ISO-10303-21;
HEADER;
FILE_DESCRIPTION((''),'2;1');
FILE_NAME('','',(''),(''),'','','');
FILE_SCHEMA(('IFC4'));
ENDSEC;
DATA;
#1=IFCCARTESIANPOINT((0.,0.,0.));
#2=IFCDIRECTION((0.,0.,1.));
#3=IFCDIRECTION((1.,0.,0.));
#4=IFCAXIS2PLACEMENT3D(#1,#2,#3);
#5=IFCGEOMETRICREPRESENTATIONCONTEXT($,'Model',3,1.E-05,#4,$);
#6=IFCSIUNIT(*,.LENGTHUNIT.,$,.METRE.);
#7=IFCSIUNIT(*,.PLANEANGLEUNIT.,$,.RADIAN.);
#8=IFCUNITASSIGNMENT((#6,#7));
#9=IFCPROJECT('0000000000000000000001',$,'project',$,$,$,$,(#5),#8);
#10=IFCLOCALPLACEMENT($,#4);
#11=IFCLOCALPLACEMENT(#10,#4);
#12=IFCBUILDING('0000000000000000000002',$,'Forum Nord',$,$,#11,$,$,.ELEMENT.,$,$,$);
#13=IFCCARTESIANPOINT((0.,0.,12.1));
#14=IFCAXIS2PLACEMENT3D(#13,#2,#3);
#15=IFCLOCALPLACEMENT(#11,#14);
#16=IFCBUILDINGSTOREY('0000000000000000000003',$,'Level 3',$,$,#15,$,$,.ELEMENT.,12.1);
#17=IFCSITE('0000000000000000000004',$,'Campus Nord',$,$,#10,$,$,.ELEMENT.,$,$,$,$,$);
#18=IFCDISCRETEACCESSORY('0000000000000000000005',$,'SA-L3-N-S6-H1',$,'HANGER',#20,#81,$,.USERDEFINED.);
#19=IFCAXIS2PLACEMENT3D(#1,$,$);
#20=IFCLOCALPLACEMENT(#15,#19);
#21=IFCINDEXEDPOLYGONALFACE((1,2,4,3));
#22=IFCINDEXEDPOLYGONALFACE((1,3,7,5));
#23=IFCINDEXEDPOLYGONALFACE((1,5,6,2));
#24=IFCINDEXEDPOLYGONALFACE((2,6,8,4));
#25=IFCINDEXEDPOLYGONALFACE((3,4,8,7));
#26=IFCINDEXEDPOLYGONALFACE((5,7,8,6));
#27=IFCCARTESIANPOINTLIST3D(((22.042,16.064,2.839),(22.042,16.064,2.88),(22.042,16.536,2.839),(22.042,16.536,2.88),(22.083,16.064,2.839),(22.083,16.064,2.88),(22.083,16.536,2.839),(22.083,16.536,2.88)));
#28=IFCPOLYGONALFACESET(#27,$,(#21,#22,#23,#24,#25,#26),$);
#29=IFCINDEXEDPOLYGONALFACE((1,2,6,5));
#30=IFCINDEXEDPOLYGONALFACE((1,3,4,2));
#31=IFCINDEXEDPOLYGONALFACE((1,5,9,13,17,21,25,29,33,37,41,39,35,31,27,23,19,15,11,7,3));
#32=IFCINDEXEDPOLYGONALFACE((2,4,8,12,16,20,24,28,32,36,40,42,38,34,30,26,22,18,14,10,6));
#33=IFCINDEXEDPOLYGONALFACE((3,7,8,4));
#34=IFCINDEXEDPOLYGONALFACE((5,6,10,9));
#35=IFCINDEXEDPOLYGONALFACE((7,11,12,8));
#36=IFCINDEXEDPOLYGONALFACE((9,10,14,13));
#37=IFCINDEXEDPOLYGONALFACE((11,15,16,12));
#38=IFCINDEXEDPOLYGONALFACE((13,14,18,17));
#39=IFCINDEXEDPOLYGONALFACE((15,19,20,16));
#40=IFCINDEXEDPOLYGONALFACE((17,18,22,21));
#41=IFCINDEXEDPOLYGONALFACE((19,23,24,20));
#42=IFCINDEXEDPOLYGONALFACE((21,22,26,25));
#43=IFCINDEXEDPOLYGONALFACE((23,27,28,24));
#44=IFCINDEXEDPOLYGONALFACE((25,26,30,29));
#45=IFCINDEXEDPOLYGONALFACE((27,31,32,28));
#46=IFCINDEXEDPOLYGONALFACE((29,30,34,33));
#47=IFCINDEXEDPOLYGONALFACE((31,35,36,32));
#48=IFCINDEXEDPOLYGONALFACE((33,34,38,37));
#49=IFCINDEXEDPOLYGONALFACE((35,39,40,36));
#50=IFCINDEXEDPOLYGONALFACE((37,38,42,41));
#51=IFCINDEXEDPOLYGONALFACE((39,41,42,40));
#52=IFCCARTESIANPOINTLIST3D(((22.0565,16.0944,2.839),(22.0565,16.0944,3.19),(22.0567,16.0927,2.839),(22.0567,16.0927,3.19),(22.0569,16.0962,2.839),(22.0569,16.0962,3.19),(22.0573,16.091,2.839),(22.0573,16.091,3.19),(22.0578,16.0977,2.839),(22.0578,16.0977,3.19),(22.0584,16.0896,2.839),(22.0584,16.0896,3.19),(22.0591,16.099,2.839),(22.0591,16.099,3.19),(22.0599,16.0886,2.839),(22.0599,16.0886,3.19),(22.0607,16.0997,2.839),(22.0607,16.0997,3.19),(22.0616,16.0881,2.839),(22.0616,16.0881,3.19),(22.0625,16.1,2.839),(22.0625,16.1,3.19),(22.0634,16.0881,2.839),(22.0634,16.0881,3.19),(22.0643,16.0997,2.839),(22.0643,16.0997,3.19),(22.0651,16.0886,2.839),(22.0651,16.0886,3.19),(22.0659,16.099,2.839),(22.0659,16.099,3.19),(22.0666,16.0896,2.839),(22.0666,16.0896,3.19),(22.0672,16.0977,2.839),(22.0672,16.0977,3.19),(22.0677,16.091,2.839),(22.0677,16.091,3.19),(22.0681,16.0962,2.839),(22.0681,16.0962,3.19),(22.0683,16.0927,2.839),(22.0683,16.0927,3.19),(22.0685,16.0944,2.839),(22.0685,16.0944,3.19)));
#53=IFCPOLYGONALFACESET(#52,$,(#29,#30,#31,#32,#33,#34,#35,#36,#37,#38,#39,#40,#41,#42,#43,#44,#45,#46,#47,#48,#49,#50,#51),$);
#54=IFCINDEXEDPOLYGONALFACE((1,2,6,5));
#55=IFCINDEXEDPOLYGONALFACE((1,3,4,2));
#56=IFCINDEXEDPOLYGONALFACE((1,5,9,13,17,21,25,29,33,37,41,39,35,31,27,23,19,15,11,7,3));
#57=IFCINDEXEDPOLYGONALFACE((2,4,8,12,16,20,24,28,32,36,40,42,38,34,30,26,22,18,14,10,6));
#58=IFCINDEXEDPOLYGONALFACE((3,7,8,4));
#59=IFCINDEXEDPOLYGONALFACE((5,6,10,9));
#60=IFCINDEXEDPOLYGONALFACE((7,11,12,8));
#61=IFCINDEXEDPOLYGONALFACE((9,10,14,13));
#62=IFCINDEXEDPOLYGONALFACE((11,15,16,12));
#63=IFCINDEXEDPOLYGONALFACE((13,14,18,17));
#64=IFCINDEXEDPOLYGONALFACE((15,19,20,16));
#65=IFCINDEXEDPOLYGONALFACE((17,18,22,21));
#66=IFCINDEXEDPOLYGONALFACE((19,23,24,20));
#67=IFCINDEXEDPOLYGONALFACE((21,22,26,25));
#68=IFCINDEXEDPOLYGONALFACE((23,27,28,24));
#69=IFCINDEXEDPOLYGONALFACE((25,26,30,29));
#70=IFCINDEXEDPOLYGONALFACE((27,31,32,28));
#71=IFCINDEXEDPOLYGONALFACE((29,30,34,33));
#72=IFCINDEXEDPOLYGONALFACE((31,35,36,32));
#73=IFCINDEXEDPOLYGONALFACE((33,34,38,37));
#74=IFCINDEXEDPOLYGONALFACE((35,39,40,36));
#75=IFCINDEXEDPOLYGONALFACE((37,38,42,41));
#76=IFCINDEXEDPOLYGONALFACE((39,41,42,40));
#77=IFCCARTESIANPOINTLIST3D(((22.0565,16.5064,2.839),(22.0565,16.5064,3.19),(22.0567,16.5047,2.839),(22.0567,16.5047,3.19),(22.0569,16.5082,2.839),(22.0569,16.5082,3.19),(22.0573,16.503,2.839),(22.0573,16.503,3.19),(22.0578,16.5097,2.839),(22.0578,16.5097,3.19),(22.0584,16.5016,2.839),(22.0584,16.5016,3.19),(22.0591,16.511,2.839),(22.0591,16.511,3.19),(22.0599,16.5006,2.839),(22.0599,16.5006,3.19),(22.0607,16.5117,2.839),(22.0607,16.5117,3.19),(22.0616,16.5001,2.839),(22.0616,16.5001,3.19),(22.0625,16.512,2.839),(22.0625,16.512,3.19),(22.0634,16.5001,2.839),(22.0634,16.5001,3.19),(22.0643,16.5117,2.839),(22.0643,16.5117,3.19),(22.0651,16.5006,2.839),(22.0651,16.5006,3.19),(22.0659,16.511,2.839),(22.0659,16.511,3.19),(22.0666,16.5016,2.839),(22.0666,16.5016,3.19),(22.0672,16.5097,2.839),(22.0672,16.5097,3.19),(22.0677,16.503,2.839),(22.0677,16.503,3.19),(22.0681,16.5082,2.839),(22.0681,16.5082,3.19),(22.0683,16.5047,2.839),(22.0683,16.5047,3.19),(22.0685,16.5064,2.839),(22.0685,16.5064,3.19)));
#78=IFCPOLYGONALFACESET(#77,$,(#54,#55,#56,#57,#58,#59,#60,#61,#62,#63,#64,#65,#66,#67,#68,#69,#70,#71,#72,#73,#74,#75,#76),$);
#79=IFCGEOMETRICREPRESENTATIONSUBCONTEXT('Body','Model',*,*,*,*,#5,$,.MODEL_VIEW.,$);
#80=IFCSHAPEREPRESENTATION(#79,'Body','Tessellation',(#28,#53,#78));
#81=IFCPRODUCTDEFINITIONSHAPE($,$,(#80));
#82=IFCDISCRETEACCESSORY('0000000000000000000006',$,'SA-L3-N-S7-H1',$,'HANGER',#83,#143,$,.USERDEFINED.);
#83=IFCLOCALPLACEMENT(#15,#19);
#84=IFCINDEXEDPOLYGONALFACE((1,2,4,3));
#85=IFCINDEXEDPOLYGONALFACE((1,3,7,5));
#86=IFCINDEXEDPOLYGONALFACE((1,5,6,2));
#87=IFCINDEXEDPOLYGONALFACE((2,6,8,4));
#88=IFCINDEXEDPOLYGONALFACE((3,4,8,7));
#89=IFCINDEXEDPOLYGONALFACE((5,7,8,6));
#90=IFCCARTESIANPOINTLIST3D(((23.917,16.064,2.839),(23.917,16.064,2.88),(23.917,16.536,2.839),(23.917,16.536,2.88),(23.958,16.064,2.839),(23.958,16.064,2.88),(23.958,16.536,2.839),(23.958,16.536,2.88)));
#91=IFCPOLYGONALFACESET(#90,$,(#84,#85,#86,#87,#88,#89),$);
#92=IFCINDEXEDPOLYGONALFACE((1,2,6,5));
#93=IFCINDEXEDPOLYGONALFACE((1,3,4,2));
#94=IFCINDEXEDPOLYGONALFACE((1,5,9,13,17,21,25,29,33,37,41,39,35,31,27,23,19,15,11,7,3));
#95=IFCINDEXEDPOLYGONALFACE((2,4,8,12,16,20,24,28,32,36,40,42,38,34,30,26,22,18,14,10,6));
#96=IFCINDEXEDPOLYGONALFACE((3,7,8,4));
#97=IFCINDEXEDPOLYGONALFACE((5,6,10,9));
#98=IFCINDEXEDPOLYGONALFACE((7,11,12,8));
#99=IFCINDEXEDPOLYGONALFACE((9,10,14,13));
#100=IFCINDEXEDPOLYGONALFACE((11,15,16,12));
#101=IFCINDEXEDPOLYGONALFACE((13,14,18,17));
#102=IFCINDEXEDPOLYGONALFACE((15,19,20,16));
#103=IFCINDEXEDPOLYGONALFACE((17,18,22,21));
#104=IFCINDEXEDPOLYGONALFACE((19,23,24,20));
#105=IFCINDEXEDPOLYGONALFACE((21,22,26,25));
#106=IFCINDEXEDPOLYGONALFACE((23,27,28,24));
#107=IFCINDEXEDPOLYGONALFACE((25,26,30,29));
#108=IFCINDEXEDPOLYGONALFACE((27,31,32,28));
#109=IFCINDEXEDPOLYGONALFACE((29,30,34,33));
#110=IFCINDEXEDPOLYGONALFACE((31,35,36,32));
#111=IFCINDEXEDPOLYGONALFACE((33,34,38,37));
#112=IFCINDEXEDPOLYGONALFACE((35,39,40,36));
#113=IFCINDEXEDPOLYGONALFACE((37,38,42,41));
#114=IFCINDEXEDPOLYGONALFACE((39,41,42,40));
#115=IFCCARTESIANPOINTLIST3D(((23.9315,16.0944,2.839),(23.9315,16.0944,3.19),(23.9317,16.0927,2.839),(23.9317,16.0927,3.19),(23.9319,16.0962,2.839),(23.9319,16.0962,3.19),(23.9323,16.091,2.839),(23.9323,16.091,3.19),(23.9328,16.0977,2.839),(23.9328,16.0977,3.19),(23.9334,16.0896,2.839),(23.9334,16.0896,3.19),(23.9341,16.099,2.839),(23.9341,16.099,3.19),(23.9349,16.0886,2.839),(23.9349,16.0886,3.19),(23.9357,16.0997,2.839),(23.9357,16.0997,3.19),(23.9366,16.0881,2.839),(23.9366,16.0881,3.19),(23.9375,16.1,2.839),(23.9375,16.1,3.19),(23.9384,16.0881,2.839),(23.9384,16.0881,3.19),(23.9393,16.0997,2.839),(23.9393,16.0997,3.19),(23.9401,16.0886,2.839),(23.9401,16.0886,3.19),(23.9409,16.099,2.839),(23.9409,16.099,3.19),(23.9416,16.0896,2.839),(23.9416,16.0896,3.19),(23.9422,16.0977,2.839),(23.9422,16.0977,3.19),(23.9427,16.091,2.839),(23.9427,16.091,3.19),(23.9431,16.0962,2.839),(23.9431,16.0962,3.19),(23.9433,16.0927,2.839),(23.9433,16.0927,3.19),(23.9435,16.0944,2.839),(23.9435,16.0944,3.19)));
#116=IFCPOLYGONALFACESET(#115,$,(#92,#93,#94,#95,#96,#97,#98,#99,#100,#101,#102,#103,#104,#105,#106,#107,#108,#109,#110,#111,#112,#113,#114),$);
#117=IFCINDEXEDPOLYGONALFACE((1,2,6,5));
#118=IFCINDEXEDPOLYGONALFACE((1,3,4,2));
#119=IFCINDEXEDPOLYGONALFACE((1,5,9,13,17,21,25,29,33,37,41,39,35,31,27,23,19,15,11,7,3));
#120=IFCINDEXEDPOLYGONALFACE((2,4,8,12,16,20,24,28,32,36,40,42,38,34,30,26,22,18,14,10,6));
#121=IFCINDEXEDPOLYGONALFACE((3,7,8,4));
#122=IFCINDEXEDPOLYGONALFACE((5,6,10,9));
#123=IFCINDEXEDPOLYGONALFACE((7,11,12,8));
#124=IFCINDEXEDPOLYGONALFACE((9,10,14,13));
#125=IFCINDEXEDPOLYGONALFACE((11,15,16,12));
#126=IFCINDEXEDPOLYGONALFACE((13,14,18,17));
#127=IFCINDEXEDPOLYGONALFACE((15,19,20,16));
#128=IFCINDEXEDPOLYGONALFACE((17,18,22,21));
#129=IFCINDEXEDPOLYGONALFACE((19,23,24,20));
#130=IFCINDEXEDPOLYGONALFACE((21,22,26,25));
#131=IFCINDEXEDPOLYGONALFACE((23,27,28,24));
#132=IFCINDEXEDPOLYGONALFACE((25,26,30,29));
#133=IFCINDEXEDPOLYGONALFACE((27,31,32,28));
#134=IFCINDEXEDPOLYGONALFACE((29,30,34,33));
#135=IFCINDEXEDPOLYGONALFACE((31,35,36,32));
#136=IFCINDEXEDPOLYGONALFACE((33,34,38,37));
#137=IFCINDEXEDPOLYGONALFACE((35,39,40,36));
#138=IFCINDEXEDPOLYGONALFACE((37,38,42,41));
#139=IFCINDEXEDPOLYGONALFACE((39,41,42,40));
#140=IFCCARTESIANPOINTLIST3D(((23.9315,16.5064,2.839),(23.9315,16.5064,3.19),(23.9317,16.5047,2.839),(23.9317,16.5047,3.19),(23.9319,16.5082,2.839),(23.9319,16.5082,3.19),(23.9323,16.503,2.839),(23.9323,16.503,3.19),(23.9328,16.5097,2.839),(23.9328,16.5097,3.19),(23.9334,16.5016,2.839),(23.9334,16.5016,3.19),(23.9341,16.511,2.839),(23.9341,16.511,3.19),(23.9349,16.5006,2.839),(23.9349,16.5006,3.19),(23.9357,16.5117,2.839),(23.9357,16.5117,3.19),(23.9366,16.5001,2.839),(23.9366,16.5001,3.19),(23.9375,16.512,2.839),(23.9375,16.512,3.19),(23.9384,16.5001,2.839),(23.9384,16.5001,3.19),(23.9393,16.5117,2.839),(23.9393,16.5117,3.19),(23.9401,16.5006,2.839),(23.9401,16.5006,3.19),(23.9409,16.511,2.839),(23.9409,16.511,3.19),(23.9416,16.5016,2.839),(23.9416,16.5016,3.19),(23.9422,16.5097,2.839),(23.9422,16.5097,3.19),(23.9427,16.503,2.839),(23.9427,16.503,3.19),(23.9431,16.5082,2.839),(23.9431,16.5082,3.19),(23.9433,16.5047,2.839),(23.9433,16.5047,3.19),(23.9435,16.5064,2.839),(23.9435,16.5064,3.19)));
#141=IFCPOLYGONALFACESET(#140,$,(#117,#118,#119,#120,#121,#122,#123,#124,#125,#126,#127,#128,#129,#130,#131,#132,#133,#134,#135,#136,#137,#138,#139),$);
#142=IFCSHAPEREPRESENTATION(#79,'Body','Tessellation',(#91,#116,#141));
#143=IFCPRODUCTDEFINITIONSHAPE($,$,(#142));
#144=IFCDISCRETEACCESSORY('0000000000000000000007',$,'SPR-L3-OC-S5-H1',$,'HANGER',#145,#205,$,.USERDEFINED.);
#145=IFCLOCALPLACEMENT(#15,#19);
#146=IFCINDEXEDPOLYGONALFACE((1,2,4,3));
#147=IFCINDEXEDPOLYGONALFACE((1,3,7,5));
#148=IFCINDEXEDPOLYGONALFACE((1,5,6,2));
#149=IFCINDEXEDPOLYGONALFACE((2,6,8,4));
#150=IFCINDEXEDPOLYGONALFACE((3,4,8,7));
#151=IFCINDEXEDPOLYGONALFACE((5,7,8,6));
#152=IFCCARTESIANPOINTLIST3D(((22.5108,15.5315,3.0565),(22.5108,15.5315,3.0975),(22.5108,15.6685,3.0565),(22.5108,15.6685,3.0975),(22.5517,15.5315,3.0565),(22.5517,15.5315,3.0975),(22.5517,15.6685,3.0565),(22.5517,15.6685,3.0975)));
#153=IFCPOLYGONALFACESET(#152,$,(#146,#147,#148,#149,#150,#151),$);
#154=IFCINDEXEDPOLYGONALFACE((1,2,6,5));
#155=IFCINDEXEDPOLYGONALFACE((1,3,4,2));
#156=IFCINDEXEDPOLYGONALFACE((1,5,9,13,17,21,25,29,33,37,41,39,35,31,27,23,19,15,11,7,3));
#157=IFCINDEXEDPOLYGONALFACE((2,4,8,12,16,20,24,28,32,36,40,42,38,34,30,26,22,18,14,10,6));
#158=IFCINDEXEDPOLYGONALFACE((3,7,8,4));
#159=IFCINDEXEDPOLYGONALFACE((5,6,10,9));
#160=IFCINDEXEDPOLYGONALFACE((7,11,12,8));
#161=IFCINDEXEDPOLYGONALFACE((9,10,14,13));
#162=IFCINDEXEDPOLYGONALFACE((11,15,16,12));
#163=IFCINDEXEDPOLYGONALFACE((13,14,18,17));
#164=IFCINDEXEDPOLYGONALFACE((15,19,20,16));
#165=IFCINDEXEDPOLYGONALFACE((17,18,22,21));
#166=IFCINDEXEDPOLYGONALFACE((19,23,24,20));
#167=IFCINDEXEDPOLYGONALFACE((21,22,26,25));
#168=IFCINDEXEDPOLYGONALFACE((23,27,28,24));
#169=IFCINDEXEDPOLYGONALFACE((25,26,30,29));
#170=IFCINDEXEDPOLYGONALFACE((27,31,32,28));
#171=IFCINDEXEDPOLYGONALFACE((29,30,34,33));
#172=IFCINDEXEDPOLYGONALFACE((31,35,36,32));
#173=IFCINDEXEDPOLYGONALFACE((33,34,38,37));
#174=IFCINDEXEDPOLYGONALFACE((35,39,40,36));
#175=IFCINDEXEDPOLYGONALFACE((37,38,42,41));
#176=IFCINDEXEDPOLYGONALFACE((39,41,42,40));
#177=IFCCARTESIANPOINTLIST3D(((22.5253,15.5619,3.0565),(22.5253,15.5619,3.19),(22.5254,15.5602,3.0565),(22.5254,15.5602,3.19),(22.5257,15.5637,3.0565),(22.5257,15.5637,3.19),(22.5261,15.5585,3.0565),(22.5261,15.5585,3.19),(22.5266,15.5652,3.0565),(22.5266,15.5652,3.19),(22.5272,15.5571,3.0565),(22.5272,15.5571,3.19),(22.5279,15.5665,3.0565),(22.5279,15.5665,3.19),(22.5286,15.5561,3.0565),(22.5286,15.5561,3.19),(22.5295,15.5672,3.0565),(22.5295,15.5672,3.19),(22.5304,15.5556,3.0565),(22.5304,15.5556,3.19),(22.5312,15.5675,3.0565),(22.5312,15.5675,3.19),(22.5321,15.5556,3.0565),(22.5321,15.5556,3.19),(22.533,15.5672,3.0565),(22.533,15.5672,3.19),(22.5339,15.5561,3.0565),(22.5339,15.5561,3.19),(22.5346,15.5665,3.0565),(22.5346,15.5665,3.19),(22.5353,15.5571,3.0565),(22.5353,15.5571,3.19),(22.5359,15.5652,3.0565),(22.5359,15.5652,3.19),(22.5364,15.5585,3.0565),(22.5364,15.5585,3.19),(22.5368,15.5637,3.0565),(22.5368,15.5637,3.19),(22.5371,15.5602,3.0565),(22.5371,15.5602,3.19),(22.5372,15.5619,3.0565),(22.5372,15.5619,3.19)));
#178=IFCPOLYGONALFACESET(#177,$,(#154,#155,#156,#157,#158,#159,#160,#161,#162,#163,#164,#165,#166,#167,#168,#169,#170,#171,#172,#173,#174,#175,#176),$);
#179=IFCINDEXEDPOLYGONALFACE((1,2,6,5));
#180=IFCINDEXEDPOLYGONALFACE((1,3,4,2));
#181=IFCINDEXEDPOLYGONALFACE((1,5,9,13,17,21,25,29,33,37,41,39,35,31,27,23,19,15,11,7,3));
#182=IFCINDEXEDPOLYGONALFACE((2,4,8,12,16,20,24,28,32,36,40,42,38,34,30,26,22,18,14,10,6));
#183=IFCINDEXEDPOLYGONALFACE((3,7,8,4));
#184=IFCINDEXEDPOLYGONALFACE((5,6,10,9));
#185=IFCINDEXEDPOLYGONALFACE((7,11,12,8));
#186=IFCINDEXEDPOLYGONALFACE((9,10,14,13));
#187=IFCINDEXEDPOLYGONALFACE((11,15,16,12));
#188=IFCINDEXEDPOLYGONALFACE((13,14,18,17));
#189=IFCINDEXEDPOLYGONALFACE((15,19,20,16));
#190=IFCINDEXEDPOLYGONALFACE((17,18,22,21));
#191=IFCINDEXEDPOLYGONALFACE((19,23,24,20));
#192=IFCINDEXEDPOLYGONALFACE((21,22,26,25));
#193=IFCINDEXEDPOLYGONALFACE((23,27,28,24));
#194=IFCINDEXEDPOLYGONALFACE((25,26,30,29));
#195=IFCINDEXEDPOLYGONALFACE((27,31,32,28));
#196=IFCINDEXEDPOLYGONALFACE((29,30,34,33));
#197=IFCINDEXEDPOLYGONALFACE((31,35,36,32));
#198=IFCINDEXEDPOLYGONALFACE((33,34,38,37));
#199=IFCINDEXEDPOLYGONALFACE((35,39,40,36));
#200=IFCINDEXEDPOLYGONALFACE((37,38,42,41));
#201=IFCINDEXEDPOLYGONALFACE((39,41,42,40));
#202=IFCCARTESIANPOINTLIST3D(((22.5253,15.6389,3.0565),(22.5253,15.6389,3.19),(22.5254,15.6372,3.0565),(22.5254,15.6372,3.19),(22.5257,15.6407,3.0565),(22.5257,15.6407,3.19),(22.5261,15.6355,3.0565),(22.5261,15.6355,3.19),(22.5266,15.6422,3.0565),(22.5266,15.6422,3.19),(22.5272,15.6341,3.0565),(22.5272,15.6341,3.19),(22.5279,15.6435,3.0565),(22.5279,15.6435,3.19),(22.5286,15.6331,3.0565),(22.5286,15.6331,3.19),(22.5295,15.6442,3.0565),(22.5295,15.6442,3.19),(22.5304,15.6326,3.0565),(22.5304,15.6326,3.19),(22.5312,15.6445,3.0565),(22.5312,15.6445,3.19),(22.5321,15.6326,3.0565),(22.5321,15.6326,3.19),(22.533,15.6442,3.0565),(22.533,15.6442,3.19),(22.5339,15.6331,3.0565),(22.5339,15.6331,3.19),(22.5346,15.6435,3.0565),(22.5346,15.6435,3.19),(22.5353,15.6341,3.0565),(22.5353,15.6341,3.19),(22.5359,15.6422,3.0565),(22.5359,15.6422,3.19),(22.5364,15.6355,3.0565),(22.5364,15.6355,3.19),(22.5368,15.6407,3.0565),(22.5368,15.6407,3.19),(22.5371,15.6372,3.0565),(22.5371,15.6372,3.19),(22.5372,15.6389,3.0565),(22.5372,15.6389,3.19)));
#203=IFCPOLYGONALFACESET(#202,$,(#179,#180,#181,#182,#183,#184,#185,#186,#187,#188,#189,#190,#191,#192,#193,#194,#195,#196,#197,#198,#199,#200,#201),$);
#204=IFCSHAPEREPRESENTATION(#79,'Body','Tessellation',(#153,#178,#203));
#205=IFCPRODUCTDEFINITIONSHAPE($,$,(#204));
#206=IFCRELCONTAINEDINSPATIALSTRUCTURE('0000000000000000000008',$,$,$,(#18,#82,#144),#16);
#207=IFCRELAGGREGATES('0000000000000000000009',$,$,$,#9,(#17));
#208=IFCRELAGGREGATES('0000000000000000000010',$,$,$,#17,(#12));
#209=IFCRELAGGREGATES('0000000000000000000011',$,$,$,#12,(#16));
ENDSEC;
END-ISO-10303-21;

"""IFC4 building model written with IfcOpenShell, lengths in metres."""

from ifc_helpers import new_model, si_unit, frame, frame_2d, origin_with_axes, origin_2d_with_axis, place, context, subcontext, project, spatial, rectangle, circle, extrude, element, save


model = new_model("IFC4")

# Units and contexts
model_context = context("Model", 3, precision=1e-05, world=origin_with_axes())
body_context = subcontext(model_context, "Body", "Model", "MODEL_VIEW")
ifc_project = project(units=[si_unit("LENGTHUNIT", "METRE"), si_unit("PLANEANGLEUNIT", "RADIAN")], contexts=[model_context])

# Site, building, storey
site_placement = place(None, origin_with_axes())
site = spatial("IfcSite", under=ifc_project, at=site_placement, Name="Campus Nord", CompositionType="ELEMENT")
building_placement = place(site_placement, origin_with_axes())
building = spatial("IfcBuilding", under=site, at=building_placement, Name="Forum Nord", CompositionType="ELEMENT")
storey_placement = place(building_placement, frame((0.0, 0.0, 12.1), z_axis=(0.0, 0.0, 1.0), x_axis=(1.0, 0.0, 0.0)))
storey = spatial("IfcBuildingStorey", under=building, at=storey_placement, Name="Level 3", CompositionType="ELEMENT", Elevation=12.1)

# Discrete accessories
for number, where, z_axis, x_axis, name in (
    (1, (22.0625, 16.3, 2.88), (0.0, 0.0, 1.0), (0.0, 1.0, 0.0), "SA-L3-N-S6-H1"),
    (2, (23.9375, 16.3, 2.88), (0.0, 0.0, 1.0), (0.0, 1.0, 0.0), "SA-L3-N-S7-H1"),
):
    element("IfcDiscreteAccessory", number, at=place(storey_placement, frame(where, z_axis=z_axis, x_axis=x_axis)), inside=storey, Name=name, ObjectType="HANGER", PredefinedType="USERDEFINED", context=body_context, shape_type="SweptSolid", body=[
        extrude(rectangle(XDim=0.472, YDim=0.041, at=origin_2d_with_axis()), frame((0.0, 0.0, -0.041), z_axis=(0.0, 0.0, 1.0), x_axis=(1.0, 0.0, 0.0)), (0.0, 0.0, 1.0), 0.041),
        extrude(circle(Radius=0.006, at=frame_2d((-0.206, 0.0), x_axis=(1.0, 0.0))), frame((0.0, 0.0, -0.041), z_axis=(0.0, 0.0, 1.0), x_axis=(1.0, 0.0, 0.0)), (0.0, 0.0, 1.0), 0.351),
        extrude(circle(Radius=0.006, at=frame_2d((0.206, 0.0), x_axis=(1.0, 0.0))), frame((0.0, 0.0, -0.041), z_axis=(0.0, 0.0, 1.0), x_axis=(1.0, 0.0, 0.0)), (0.0, 0.0, 1.0), 0.351),
    ])
for number, where, z_axis, x_axis, name in (
    (3, (22.5312, 15.6, 3.0975), (0.0, 0.0, 1.0), (0.0, 1.0, 0.0), "SPR-L3-OC-S5-H1"),
):
    element("IfcDiscreteAccessory", number, at=place(storey_placement, frame(where, z_axis=z_axis, x_axis=x_axis)), inside=storey, Name=name, ObjectType="HANGER", PredefinedType="USERDEFINED", context=body_context, shape_type="SweptSolid", body=[
        extrude(rectangle(XDim=0.137, YDim=0.041, at=origin_2d_with_axis()), frame((0.0, 0.0, -0.041), z_axis=(0.0, 0.0, 1.0), x_axis=(1.0, 0.0, 0.0)), (0.0, 0.0, 1.0), 0.041),
        extrude(circle(Radius=0.006, at=frame_2d((-0.0385, 0.0), x_axis=(1.0, 0.0))), frame((0.0, 0.0, -0.041), z_axis=(0.0, 0.0, 1.0), x_axis=(1.0, 0.0, 0.0)), (0.0, 0.0, 1.0), 0.1335),
        extrude(circle(Radius=0.006, at=frame_2d((0.0385, 0.0), x_axis=(1.0, 0.0))), frame((0.0, 0.0, -0.041), z_axis=(0.0, 0.0, 1.0), x_axis=(1.0, 0.0, 0.0)), (0.0, 0.0, 1.0), 0.1335),
    ])

save(model, "model.ifc")
